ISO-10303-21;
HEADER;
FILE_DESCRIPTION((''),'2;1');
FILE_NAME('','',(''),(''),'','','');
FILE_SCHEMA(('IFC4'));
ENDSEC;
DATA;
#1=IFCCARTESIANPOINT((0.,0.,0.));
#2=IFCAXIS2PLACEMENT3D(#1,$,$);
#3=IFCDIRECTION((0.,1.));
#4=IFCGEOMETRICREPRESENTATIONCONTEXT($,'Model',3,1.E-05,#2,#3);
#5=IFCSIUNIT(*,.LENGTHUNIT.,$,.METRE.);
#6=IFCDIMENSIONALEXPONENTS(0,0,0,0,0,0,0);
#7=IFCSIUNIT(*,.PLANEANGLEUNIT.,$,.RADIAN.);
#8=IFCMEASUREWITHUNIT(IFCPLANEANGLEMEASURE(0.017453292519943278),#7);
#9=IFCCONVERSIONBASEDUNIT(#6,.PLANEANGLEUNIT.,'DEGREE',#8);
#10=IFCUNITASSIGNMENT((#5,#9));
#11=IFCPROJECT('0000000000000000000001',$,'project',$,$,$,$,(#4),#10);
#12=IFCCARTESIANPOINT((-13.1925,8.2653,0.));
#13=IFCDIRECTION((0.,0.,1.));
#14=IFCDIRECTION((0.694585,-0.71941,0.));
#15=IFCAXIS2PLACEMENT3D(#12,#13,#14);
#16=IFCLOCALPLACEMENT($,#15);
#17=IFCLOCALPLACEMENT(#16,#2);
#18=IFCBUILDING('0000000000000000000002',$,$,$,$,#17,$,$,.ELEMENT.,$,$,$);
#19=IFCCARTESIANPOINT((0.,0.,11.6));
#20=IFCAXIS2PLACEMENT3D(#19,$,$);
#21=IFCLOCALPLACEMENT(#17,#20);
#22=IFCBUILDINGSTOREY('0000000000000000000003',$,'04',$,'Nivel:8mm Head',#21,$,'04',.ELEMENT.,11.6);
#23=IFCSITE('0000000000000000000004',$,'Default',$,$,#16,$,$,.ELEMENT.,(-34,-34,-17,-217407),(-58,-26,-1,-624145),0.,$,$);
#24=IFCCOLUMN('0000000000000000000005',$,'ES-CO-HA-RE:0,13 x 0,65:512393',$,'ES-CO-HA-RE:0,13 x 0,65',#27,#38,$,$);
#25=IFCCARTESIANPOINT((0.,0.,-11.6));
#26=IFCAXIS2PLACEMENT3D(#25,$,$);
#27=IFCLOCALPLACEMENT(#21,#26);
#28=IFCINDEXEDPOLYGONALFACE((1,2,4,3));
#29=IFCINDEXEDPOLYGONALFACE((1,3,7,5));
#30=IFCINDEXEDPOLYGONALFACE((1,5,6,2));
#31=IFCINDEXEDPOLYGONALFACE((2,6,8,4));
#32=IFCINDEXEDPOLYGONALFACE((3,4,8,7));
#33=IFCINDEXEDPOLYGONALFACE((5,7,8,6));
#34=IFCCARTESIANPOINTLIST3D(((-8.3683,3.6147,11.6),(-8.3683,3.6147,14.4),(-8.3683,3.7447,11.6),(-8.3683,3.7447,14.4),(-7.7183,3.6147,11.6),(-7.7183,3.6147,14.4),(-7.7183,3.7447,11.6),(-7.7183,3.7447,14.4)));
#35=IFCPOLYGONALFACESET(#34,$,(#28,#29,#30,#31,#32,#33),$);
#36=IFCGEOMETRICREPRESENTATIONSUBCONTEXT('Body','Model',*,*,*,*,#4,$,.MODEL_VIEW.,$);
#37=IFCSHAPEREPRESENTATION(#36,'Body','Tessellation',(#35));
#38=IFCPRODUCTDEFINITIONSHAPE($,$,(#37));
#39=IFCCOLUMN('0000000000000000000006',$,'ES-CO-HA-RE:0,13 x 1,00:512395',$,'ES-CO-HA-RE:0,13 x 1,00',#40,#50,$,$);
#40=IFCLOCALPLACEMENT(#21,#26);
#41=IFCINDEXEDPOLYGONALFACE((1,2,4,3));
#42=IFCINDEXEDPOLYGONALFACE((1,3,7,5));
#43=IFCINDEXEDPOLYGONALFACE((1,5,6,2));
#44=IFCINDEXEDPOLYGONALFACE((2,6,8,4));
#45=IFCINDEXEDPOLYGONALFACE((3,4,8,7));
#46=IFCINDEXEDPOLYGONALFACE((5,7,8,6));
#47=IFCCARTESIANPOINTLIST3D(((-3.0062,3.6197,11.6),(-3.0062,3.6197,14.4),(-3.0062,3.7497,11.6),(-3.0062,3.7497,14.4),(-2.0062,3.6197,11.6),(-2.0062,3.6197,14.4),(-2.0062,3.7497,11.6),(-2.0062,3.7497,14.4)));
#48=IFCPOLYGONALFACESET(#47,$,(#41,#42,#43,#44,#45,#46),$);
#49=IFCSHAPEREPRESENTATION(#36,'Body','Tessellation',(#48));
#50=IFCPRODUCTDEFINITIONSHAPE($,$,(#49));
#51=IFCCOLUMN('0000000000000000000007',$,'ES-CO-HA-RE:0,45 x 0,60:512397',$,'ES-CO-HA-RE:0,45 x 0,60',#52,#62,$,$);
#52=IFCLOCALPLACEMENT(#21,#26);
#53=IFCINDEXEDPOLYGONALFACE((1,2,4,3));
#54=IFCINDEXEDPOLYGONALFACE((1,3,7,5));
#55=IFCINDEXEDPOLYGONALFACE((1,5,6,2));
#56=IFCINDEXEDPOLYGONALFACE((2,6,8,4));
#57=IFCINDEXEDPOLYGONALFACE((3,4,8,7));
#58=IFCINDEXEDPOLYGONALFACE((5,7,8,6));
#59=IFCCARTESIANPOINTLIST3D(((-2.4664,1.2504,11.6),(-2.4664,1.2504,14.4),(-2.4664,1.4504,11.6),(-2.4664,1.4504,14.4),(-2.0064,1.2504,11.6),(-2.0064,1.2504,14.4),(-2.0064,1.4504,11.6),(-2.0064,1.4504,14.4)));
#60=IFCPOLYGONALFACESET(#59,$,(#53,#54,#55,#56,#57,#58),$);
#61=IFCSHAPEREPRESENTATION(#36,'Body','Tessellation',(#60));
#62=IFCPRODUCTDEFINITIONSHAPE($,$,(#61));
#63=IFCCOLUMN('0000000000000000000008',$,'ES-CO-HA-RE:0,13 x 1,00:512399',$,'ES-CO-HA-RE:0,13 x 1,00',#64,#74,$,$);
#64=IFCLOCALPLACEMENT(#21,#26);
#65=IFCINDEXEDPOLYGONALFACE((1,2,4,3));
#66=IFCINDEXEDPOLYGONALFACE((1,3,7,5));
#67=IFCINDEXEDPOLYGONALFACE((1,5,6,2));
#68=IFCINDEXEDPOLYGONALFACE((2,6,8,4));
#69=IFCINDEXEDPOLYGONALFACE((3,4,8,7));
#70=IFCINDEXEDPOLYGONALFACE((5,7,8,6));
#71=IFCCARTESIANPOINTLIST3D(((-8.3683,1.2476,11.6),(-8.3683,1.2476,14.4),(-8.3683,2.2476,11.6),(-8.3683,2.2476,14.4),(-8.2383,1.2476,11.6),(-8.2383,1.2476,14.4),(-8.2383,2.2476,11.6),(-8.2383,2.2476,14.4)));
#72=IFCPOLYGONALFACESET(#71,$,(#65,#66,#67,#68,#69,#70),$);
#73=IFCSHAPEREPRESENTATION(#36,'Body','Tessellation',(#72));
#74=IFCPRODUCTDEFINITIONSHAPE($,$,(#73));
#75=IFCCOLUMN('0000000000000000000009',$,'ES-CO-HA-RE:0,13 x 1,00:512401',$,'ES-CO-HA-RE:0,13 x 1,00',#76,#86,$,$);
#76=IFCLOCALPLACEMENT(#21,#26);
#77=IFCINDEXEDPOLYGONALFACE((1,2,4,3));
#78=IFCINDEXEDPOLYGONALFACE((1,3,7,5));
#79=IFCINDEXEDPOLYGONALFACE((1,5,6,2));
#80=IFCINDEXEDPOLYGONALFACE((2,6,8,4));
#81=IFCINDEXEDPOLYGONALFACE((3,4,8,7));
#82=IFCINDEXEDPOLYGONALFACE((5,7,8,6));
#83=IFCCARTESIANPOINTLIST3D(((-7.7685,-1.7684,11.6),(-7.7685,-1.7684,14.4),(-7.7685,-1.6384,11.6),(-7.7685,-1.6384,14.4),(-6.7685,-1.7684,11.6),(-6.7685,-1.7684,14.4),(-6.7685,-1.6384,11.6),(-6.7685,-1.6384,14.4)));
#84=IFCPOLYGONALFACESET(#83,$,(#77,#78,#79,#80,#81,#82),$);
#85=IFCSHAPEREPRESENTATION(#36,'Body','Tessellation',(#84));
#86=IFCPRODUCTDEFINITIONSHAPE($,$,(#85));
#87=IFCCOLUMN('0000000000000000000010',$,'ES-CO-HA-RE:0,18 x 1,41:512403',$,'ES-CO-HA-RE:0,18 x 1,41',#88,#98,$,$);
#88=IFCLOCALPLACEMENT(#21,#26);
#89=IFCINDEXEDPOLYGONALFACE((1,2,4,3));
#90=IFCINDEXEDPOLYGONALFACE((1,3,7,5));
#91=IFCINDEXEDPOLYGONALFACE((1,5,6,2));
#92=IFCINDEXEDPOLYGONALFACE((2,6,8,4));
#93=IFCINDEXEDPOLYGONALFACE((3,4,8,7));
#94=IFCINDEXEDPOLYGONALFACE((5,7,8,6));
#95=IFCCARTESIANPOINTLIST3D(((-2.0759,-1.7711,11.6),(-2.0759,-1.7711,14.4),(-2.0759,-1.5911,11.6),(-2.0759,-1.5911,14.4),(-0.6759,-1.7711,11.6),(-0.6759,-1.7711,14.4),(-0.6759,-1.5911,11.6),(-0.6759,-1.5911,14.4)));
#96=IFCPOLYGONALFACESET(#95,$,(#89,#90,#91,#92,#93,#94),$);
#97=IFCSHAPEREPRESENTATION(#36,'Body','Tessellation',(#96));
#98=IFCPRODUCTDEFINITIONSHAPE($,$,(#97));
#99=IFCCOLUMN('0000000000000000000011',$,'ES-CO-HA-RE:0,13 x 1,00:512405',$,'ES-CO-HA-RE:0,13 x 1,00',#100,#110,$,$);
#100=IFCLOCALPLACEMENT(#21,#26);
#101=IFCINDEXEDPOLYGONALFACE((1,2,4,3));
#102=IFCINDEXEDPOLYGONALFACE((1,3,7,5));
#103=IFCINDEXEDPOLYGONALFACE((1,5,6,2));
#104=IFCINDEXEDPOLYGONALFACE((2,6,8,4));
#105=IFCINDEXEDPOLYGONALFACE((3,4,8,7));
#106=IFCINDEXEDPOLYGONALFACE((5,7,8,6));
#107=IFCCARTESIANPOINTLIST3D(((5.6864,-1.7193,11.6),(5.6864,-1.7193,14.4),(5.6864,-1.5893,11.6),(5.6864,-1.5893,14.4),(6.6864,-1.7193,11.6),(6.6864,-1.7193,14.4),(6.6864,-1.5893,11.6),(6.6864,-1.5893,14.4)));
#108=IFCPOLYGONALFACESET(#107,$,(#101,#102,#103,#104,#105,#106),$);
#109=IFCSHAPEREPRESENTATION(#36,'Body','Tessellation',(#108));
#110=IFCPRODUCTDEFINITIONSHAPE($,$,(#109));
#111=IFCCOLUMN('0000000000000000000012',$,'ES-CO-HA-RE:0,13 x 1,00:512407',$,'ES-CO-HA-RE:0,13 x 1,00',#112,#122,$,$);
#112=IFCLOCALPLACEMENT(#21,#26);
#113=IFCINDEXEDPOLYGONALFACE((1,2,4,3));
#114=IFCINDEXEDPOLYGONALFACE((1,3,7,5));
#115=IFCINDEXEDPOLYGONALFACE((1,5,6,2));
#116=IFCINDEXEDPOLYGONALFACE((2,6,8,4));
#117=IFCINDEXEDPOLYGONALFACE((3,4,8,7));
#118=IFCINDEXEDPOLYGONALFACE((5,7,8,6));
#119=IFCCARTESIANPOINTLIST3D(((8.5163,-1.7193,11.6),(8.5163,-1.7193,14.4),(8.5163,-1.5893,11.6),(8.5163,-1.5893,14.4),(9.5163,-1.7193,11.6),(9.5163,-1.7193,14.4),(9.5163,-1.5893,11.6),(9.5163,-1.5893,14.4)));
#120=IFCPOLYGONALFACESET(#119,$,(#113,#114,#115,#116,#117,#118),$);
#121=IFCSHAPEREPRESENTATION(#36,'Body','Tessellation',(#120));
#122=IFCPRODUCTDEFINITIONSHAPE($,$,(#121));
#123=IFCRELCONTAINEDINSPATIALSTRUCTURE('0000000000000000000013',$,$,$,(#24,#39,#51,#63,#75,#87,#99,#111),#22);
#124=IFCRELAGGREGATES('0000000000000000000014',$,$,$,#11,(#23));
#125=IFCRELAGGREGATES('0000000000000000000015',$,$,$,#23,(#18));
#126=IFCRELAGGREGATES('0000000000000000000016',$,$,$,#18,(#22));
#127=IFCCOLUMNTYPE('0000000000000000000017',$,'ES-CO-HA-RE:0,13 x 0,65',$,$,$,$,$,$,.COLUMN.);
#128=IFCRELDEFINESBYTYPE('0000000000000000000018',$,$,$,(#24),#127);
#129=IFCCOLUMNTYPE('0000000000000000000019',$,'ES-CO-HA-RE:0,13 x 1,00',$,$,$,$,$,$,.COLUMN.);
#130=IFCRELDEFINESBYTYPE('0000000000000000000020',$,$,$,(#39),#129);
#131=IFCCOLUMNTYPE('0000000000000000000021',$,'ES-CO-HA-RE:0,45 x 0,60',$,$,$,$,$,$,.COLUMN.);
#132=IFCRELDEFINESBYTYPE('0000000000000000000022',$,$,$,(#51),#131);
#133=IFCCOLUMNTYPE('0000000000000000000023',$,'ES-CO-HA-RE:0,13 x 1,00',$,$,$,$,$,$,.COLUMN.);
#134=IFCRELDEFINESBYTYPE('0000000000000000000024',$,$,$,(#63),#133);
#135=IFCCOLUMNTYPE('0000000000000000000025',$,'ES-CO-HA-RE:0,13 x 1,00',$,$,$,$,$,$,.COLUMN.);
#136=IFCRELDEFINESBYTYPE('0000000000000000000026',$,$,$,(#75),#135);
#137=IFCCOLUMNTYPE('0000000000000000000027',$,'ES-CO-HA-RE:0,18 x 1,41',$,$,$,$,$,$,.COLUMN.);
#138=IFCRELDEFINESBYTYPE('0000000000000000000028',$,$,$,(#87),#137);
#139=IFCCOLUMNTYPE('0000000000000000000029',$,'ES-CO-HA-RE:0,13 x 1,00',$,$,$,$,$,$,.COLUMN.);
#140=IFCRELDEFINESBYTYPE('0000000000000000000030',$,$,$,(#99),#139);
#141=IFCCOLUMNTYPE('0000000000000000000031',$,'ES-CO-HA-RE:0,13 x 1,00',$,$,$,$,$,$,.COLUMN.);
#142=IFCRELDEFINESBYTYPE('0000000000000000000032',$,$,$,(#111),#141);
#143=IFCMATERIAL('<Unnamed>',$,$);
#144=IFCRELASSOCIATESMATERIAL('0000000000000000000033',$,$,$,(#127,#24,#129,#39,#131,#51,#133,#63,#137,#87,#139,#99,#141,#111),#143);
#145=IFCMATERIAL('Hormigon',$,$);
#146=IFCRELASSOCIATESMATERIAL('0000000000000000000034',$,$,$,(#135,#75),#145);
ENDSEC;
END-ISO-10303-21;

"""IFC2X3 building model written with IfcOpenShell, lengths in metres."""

from ifc_helpers import new_model, entity, si_unit, converted_unit, direction, frame, frame_2d, origin, origin_2d_with_axis, place, context, subcontext, project, spatial, rectangle, extrude, source, transform, mapped, material, type_object, type_shapes, element, save


model = new_model("IFC2X3")

# Units and contexts
model_context = context("Model", 3, precision=1e-05, world=origin(), true_north=direction((0.0, 1.0)))
body_context = subcontext(model_context, "Body", "Model", "MODEL_VIEW")
ifc_project = project(units=[si_unit("LENGTHUNIT", "METRE"), converted_unit("PLANEANGLEUNIT", "DEGREE", entity("IfcPlaneAngleMeasure", 0.017453292519943278), si_unit("PLANEANGLEUNIT", "RADIAN"), dimensions=[0, 0, 0, 0, 0, 0, 0])], contexts=[model_context])

# Site, building, storey
site_placement = place(None, frame((-13.1925, 8.2653, 0.0), z_axis=(0.0, 0.0, 1.0), x_axis=(0.694585, -0.71941, 0.0)))
site = spatial("IfcSite", under=ifc_project, at=site_placement, Name="Default", CompositionType="ELEMENT", RefLatitude=(-34, -34, -17, -217407), RefLongitude=(-58, -26, -1, -624145), RefElevation=0.0)
building_placement = place(site_placement, origin())
building = spatial("IfcBuilding", under=site, at=building_placement, CompositionType="ELEMENT")
storey_placement = place(building_placement, frame((0.0, 0.0, 11.6)))
storey = spatial("IfcBuildingStorey", under=building, at=storey_placement, Name="04", ObjectType="Nivel:8mm Head", LongName="04", CompositionType="ELEMENT", Elevation=11.6)

# Columns
ifc_material_1 = material(Name="<Unnamed>")
column_type_1 = type_object("IfcColumnType", Name="ES-CO-HA-RE:0,13 x 0,65", PredefinedType="COLUMN", material=ifc_material_1)
shared_shape_1 = source(origin(), body_context, "Body", "SweptSolid", [
    extrude(rectangle(XDim=0.65, YDim=0.13, at=origin_2d_with_axis()), frame((-8.0433, 3.6797, 11.6), z_axis=(0.0, 0.0, 1.0), x_axis=(-1.0, 0.0, 0.0)), (0.0, 0.0, 1.0), 2.8),
])
type_shapes(column_type_1, [shared_shape_1])
column_1_placement = place(storey_placement, frame((0.0, 0.0, -11.6)))
element("IfcColumn", 1, at=column_1_placement, inside=storey, type_object=column_type_1, material=ifc_material_1, Name="ES-CO-HA-RE:0,13 x 0,65:512393", ObjectType="ES-CO-HA-RE:0,13 x 0,65", context=body_context, shape_type="MappedRepresentation", body=[
    mapped(shared_shape_1, transform((0.0, 0.0, 0.0), scale=1.0)),
])
column_type_2 = type_object("IfcColumnType", Name="ES-CO-HA-RE:0,13 x 1,00", PredefinedType="COLUMN", material=ifc_material_1)
shared_shape_2 = source(origin(), body_context, "Body", "SweptSolid", [
    extrude(rectangle(XDim=1.0, YDim=0.13, at=frame_2d((0.0, 0.0), x_axis=(1.0, 0.0))), frame((-2.5062, 3.6847, 11.6), z_axis=(0.0, 0.0, 1.0), x_axis=(-1.0, 0.0, 0.0)), (0.0, 0.0, 1.0), 2.8),
])
type_shapes(column_type_2, [shared_shape_2])
column_2_placement = place(storey_placement, frame((0.0, 0.0, -11.6)))
element("IfcColumn", 2, at=column_2_placement, inside=storey, type_object=column_type_2, material=ifc_material_1, Name="ES-CO-HA-RE:0,13 x 1,00:512395", ObjectType="ES-CO-HA-RE:0,13 x 1,00", context=body_context, shape_type="MappedRepresentation", body=[
    mapped(shared_shape_2, transform((0.0, 0.0, 0.0), scale=1.0)),
])
column_type_3 = type_object("IfcColumnType", Name="ES-CO-HA-RE:0,45 x 0,60", PredefinedType="COLUMN", material=ifc_material_1)
shared_shape_3 = source(origin(), body_context, "Body", "SweptSolid", [
    extrude(rectangle(XDim=0.46, YDim=0.2, at=frame_2d((0.0, 0.0), x_axis=(1.0, 0.0))), frame((-2.2364, 1.3504, 11.6), z_axis=(0.0, 0.0, 1.0), x_axis=(-1.0, 0.0, 0.0)), (0.0, 0.0, 1.0), 2.8),
])
type_shapes(column_type_3, [shared_shape_3])
column_3_placement = place(storey_placement, frame((0.0, 0.0, -11.6)))
element("IfcColumn", 3, at=column_3_placement, inside=storey, type_object=column_type_3, material=ifc_material_1, Name="ES-CO-HA-RE:0,45 x 0,60:512397", ObjectType="ES-CO-HA-RE:0,45 x 0,60", context=body_context, shape_type="MappedRepresentation", body=[
    mapped(shared_shape_3, transform((0.0, 0.0, 0.0), scale=1.0)),
])
column_type_4 = type_object("IfcColumnType", Name="ES-CO-HA-RE:0,13 x 1,00", PredefinedType="COLUMN", material=ifc_material_1)
shared_shape_4 = source(origin(), body_context, "Body", "SweptSolid", [
    extrude(rectangle(XDim=1.0, YDim=0.13, at=frame_2d((0.0, 0.0), x_axis=(1.0, 0.0))), frame((-8.3033, 1.7476, 11.6), z_axis=(0.0, 0.0, 1.0), x_axis=(0.0, -1.0, 0.0)), (0.0, 0.0, 1.0), 2.8),
])
type_shapes(column_type_4, [shared_shape_4])
column_4_placement = place(storey_placement, frame((0.0, 0.0, -11.6)))
element("IfcColumn", 4, at=column_4_placement, inside=storey, type_object=column_type_4, material=ifc_material_1, Name="ES-CO-HA-RE:0,13 x 1,00:512399", ObjectType="ES-CO-HA-RE:0,13 x 1,00", context=body_context, shape_type="MappedRepresentation", body=[
    mapped(shared_shape_4, transform((0.0, 0.0, 0.0), scale=1.0)),
])
ifc_material_2 = material(Name="Hormigon")
column_type_5 = type_object("IfcColumnType", Name="ES-CO-HA-RE:0,13 x 1,00", PredefinedType="COLUMN", material=ifc_material_2)
shared_shape_5 = source(origin(), body_context, "Body", "SweptSolid", [
    extrude(rectangle(XDim=1.0, YDim=0.13, at=frame_2d((0.0, 0.0), x_axis=(1.0, 0.0))), frame((-7.2685, -1.7034, 11.6), z_axis=(0.0, 0.0, 1.0), x_axis=(-1.0, 0.0, 0.0)), (0.0, 0.0, 1.0), 2.8),
])
type_shapes(column_type_5, [shared_shape_5])
column_5_placement = place(storey_placement, frame((0.0, 0.0, -11.6)))
element("IfcColumn", 5, at=column_5_placement, inside=storey, type_object=column_type_5, material=ifc_material_2, Name="ES-CO-HA-RE:0,13 x 1,00:512401", ObjectType="ES-CO-HA-RE:0,13 x 1,00", context=body_context, shape_type="MappedRepresentation", body=[
    mapped(shared_shape_5, transform((0.0, 0.0, 0.0), scale=1.0)),
])
column_type_6 = type_object("IfcColumnType", Name="ES-CO-HA-RE:0,18 x 1,41", PredefinedType="COLUMN", material=ifc_material_1)
shared_shape_6 = source(origin(), body_context, "Body", "SweptSolid", [
    extrude(rectangle(XDim=1.4, YDim=0.18, at=frame_2d((0.0, 0.0), x_axis=(1.0, 0.0))), frame((-1.3759, -1.6811, 11.6), z_axis=(0.0, 0.0, 1.0), x_axis=(-1.0, 0.0, 0.0)), (0.0, 0.0, 1.0), 2.8),
])
type_shapes(column_type_6, [shared_shape_6])
column_6_placement = place(storey_placement, frame((0.0, 0.0, -11.6)))
element("IfcColumn", 6, at=column_6_placement, inside=storey, type_object=column_type_6, material=ifc_material_1, Name="ES-CO-HA-RE:0,18 x 1,41:512403", ObjectType="ES-CO-HA-RE:0,18 x 1,41", context=body_context, shape_type="MappedRepresentation", body=[
    mapped(shared_shape_6, transform((0.0, 0.0, 0.0), scale=1.0)),
])
column_type_7 = type_object("IfcColumnType", Name="ES-CO-HA-RE:0,13 x 1,00", PredefinedType="COLUMN", material=ifc_material_1)
shared_shape_7 = source(origin(), body_context, "Body", "SweptSolid", [
    extrude(rectangle(XDim=1.0, YDim=0.13, at=frame_2d((0.0, 0.0), x_axis=(1.0, 0.0))), frame((6.1864, -1.6543, 11.6), z_axis=(0.0, 0.0, 1.0), x_axis=(-1.0, 0.0, 0.0)), (0.0, 0.0, 1.0), 2.8),
])
type_shapes(column_type_7, [shared_shape_7])
column_7_placement = place(storey_placement, frame((0.0, 0.0, -11.6)))
element("IfcColumn", 7, at=column_7_placement, inside=storey, type_object=column_type_7, material=ifc_material_1, Name="ES-CO-HA-RE:0,13 x 1,00:512405", ObjectType="ES-CO-HA-RE:0,13 x 1,00", context=body_context, shape_type="MappedRepresentation", body=[
    mapped(shared_shape_7, transform((0.0, 0.0, 0.0), scale=1.0)),
])
column_type_8 = type_object("IfcColumnType", Name="ES-CO-HA-RE:0,13 x 1,00", PredefinedType="COLUMN", material=ifc_material_1)
shared_shape_8 = source(origin(), body_context, "Body", "SweptSolid", [
    extrude(rectangle(XDim=1.0, YDim=0.13, at=frame_2d((0.0, 0.0), x_axis=(1.0, 0.0))), frame((9.0163, -1.6543, 11.6), z_axis=(0.0, 0.0, 1.0), x_axis=(-1.0, 0.0, 0.0)), (0.0, 0.0, 1.0), 2.8),
])
type_shapes(column_type_8, [shared_shape_8])
column_8_placement = place(storey_placement, frame((0.0, 0.0, -11.6)))
element("IfcColumn", 8, at=column_8_placement, inside=storey, type_object=column_type_8, material=ifc_material_1, Name="ES-CO-HA-RE:0,13 x 1,00:512407", ObjectType="ES-CO-HA-RE:0,13 x 1,00", context=body_context, shape_type="MappedRepresentation", body=[
    mapped(shared_shape_8, transform((0.0, 0.0, 0.0), scale=1.0)),
])

save(model, "model.ifc")
